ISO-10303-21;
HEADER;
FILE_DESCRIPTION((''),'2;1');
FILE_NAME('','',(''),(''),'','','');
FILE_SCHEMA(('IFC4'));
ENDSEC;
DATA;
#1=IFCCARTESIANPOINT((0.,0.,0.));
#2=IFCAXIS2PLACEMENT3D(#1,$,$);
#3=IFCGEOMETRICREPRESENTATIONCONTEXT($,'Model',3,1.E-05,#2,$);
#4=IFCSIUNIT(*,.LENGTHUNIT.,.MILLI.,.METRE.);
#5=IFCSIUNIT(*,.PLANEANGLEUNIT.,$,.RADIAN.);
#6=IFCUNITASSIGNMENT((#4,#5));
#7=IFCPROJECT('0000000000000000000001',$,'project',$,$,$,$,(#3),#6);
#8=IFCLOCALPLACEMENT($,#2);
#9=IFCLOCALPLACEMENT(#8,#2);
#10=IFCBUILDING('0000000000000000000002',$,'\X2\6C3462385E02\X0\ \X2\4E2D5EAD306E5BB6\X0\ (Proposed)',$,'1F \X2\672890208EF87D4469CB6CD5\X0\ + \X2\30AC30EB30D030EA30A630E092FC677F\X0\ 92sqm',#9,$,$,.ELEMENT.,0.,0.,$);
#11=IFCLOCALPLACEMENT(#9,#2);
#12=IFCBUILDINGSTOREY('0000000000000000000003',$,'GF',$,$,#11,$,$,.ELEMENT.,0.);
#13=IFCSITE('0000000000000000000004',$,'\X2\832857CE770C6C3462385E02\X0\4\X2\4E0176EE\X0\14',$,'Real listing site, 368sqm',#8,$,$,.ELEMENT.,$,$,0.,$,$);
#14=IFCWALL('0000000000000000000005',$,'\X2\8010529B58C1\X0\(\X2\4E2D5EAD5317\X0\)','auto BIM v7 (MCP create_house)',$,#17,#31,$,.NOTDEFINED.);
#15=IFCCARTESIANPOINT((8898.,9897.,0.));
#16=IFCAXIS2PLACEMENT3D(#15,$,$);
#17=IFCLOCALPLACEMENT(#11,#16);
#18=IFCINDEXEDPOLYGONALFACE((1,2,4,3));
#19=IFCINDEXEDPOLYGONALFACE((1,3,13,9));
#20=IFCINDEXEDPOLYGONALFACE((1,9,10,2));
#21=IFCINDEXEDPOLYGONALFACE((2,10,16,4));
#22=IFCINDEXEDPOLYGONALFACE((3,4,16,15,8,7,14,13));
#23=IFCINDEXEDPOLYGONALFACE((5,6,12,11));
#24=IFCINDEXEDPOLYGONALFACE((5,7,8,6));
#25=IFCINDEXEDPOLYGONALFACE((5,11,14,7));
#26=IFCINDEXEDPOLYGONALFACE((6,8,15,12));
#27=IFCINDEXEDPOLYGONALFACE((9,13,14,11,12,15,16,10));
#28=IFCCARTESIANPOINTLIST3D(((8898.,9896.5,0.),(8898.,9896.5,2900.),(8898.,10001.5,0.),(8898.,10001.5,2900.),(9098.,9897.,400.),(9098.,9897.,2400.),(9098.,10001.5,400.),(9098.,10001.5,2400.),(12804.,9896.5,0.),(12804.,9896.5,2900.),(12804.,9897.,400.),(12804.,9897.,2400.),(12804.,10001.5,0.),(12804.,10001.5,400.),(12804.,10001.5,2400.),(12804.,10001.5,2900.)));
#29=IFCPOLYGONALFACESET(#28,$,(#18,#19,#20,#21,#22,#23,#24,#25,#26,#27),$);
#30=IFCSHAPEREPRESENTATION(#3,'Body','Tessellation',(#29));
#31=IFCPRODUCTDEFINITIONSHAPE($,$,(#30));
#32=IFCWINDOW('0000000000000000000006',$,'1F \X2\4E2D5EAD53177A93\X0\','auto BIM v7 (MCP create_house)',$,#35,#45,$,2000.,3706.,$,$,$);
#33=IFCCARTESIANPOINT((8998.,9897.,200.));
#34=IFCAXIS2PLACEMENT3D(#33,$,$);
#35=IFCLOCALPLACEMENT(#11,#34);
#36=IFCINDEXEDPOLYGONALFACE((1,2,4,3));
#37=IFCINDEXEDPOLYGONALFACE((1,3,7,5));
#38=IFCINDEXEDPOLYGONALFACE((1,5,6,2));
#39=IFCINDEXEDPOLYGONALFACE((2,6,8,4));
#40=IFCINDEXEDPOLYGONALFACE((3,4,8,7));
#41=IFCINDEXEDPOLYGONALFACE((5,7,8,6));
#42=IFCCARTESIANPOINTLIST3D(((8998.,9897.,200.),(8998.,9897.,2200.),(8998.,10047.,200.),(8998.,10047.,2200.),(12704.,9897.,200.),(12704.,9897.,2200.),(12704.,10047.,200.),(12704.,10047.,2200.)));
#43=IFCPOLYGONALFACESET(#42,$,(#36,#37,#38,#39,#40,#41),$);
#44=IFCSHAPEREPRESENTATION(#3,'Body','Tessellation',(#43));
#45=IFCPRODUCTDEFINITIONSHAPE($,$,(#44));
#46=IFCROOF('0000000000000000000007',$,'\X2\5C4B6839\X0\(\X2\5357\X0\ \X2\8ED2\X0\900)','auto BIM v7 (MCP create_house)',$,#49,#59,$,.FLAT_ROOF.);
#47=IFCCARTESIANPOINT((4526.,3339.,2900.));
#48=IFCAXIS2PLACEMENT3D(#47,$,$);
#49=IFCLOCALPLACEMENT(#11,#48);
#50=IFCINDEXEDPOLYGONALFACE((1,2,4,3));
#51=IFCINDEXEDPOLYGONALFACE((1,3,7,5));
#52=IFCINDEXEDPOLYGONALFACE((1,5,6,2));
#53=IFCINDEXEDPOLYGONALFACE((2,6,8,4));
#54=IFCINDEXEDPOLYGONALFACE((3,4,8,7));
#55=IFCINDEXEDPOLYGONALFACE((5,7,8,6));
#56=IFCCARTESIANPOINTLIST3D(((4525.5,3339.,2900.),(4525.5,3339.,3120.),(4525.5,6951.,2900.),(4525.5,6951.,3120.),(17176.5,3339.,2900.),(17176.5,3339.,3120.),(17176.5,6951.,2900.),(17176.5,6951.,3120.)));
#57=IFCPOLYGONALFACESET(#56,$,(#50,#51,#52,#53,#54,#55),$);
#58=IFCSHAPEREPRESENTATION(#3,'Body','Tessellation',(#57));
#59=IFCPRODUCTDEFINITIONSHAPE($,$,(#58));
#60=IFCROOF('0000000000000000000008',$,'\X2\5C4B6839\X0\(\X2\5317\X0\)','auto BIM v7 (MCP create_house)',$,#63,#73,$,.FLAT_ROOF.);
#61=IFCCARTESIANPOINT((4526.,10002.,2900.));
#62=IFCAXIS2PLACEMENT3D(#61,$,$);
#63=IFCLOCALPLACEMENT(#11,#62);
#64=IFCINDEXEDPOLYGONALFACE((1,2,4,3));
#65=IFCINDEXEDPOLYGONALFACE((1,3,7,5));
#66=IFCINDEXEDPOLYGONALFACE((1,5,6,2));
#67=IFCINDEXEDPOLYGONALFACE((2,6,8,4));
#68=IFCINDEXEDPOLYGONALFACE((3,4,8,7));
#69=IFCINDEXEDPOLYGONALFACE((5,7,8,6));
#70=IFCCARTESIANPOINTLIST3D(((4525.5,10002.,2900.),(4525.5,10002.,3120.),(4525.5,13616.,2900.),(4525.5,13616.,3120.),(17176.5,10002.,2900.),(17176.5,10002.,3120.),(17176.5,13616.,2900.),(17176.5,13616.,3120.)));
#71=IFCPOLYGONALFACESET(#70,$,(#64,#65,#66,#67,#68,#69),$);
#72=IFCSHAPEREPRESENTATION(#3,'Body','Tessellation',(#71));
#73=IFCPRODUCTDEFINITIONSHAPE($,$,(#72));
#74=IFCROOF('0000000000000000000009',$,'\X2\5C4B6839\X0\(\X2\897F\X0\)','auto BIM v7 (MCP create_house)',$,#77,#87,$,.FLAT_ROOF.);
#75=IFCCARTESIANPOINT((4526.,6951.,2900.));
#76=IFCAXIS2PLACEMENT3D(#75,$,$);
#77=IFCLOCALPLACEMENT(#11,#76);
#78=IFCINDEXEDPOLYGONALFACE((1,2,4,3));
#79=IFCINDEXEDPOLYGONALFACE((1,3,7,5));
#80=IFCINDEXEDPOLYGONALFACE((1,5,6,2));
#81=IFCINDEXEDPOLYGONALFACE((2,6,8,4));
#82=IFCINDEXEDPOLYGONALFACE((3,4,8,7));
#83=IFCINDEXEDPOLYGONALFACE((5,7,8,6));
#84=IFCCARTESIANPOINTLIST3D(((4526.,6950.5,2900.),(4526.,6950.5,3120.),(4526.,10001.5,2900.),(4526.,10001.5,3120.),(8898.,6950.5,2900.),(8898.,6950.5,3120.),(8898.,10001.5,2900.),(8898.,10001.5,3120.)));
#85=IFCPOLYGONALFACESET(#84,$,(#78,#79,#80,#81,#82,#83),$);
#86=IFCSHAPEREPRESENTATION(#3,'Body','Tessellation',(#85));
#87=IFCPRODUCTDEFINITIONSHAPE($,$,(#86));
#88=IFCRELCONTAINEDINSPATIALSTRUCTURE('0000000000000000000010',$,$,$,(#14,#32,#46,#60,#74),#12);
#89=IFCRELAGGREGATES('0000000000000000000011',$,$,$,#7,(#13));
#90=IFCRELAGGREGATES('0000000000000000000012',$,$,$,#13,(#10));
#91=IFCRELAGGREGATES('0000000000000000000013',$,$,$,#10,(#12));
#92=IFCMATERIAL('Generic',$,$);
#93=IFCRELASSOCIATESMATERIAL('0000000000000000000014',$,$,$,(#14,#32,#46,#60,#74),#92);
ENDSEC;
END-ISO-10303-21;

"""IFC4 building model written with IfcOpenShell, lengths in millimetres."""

from ifc_helpers import new_model, si_unit, frame, frame_2d, origin, place, context, project, spatial, rectangle, extrude, material, element, fill, save


model = new_model("IFC4")

# Units and contexts
model_context = context("Model", 3, precision=1e-05, world=origin())
ifc_project = project(units=[si_unit("LENGTHUNIT", "METRE", prefix="MILLI"), si_unit("PLANEANGLEUNIT", "RADIAN")], contexts=[model_context])

# Site, building, storey
site_placement = place(None, origin())
site = spatial("IfcSite", under=ifc_project, at=site_placement, Name="茨城県水戸市4丁目14", ObjectType="Real listing site, 368sqm", CompositionType="ELEMENT", RefElevation=0.0)
building_placement = place(site_placement, origin())
building = spatial("IfcBuilding", under=site, at=building_placement, Name="水戸市 中庭の家 (Proposed)", ObjectType="1F 木造軸組構法 + ガルバリウム鋼板 92sqm", CompositionType="ELEMENT", ElevationOfRefHeight=0.0, ElevationOfTerrain=0.0)
storey_placement = place(building_placement, origin())
storey = spatial("IfcBuildingStorey", under=building, at=storey_placement, Name="GF", CompositionType="ELEMENT", Elevation=0.0)

# Shared definitions
ifc_material = material(Name="Generic")

# Wall, opening, window
wall_1_placement = place(storey_placement, frame((8898.0, 9897.0, 0.0)))
wall_1 = element("IfcWall", 1, at=wall_1_placement, inside=storey, material=ifc_material, Name="耐力壁(中庭北)", Description="auto BIM v7 (MCP create_house)", PredefinedType="NOTDEFINED", context=model_context, shape_type="SweptSolid", body=[
    extrude(rectangle(XDim=3906.0, YDim=105.0, at=frame_2d((1953.0, 52.0))), frame((8898.0, 9897.0, 0.0)), (0.0, 0.0, 1.0), 2900.0),
])
opening_1_placement = place(storey_placement, frame((8998.0, 9897.0, 200.0)))
opening_1 = element("IfcOpeningElement", 2, at=opening_1_placement, cuts=wall_1, PredefinedType="NOTDEFINED", context=model_context, shape_type="SweptSolid", body=[
    extrude(rectangle(XDim=3706.0, YDim=150.0, at=frame_2d((1853.0, 75.0))), frame((8998.0, 9897.0, 200.0)), (0.0, 0.0, 1.0), 2000.0),
])
window_1_placement = place(storey_placement, frame((8998.0, 9897.0, 200.0)))
window_1 = element("IfcWindow", 3, at=window_1_placement, inside=storey, material=ifc_material, Name="1F 中庭北窓", Description="auto BIM v7 (MCP create_house)", OverallHeight=2000.0, OverallWidth=3706.0, context=model_context, shape_type="SweptSolid", body=[
    extrude(rectangle(XDim=3706.0, YDim=150.0, at=frame_2d((1853.0, 75.0))), frame((8998.0, 9897.0, 200.0)), (0.0, 0.0, 1.0), 2000.0),
])
fill(opening_1, window_1)

# Roofs
roof_1_placement = place(storey_placement, frame((4526.0, 3339.0, 2900.0)))
element("IfcRoof", 4, at=roof_1_placement, inside=storey, material=ifc_material, Name="屋根(南 軒900)", Description="auto BIM v7 (MCP create_house)", PredefinedType="FLAT_ROOF", context=model_context, shape_type="SweptSolid", body=[
    extrude(rectangle(XDim=12651.0, YDim=3612.0, at=frame_2d((6325.0, 1806.0))), frame((4526.0, 3339.0, 2900.0)), (0.0, 0.0, 1.0), 220.0),
])
roof_2_placement = place(storey_placement, frame((4526.0, 10002.0, 2900.0)))
element("IfcRoof", 5, at=roof_2_placement, inside=storey, material=ifc_material, Name="屋根(北)", Description="auto BIM v7 (MCP create_house)", PredefinedType="FLAT_ROOF", context=model_context, shape_type="SweptSolid", body=[
    extrude(rectangle(XDim=12651.0, YDim=3614.0, at=frame_2d((6325.0, 1807.0))), frame((4526.0, 10002.0, 2900.0)), (0.0, 0.0, 1.0), 220.0),
])
roof_3_placement = place(storey_placement, frame((4526.0, 6951.0, 2900.0)))
element("IfcRoof", 6, at=roof_3_placement, inside=storey, material=ifc_material, Name="屋根(西)", Description="auto BIM v7 (MCP create_house)", PredefinedType="FLAT_ROOF", context=model_context, shape_type="SweptSolid", body=[
    extrude(rectangle(XDim=4372.0, YDim=3051.0, at=frame_2d((2186.0, 1525.0))), frame((4526.0, 6951.0, 2900.0)), (0.0, 0.0, 1.0), 220.0),
])

save(model, "model.ifc")
